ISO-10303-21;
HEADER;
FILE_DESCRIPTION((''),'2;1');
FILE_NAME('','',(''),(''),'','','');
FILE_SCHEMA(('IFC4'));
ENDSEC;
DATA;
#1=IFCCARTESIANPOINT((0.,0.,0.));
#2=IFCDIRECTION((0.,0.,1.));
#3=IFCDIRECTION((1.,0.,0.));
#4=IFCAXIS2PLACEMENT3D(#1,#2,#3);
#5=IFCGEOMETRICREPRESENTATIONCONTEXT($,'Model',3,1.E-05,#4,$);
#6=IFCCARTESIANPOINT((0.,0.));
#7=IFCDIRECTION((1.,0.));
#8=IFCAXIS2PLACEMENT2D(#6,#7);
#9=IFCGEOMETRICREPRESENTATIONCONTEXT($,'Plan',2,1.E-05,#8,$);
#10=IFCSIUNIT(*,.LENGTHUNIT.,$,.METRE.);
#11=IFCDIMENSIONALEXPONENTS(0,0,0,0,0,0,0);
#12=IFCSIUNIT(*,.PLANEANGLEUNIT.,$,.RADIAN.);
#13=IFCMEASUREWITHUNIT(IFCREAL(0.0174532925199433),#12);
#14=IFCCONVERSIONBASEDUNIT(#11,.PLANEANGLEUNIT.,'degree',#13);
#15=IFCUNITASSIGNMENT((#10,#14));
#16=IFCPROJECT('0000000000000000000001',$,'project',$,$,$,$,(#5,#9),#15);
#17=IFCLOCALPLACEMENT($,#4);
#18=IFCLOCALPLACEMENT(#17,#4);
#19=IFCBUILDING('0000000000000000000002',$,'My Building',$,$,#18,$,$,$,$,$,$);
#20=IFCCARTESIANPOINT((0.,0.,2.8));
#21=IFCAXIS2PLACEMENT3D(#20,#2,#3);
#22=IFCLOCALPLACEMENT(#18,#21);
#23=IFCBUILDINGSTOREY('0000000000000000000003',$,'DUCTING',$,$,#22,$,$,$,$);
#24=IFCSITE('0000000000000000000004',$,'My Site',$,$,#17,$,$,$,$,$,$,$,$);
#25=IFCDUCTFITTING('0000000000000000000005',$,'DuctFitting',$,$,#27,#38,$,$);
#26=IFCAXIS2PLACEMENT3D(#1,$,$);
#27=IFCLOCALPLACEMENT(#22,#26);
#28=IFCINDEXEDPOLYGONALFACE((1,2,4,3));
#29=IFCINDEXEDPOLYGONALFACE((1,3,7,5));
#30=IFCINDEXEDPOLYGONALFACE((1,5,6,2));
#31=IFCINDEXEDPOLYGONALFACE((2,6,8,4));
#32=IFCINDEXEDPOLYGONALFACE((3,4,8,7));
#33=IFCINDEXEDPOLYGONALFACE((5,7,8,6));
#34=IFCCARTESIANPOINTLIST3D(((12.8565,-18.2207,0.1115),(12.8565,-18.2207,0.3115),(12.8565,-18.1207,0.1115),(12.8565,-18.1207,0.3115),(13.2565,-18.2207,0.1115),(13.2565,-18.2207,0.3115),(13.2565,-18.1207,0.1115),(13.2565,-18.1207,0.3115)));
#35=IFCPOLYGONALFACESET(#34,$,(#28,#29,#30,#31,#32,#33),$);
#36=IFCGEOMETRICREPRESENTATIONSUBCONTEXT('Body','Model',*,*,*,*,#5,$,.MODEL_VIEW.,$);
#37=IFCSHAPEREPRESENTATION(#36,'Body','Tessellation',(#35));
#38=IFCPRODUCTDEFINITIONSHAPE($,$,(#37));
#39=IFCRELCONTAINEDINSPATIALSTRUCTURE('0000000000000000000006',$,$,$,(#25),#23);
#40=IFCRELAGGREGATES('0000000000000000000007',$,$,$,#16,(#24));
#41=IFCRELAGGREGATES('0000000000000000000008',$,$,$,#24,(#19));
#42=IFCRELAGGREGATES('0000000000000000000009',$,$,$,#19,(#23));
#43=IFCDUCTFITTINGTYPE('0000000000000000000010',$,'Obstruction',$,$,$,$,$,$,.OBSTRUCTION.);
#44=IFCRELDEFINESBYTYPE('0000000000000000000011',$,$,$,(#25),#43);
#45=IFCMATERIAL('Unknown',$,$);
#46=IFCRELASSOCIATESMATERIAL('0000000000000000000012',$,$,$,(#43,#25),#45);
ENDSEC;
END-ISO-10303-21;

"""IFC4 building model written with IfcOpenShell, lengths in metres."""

from ifc_helpers import new_model, entity, si_unit, converted_unit, frame, origin_with_axes, origin_2d_with_axis, place, context, subcontext, project, spatial, rectangle, extrude, material, material_profile, profile_set, profile_usage, type_object, element, save


model = new_model("IFC4")

# Units and contexts
model_context = context("Model", 3, precision=1e-05, world=origin_with_axes())
plan_context = context("Plan", 2, precision=1e-05, world=origin_2d_with_axis())
body_context = subcontext(model_context, "Body", "Model", "MODEL_VIEW")
ifc_project = project(units=[si_unit("LENGTHUNIT", "METRE"), converted_unit("PLANEANGLEUNIT", "degree", entity("IfcReal", 0.0174532925199433), si_unit("PLANEANGLEUNIT", "RADIAN"), dimensions=[0, 0, 0, 0, 0, 0, 0])], contexts=[model_context, plan_context])

# Site, building, storey
site_placement = place(None, origin_with_axes())
site = spatial("IfcSite", under=ifc_project, at=site_placement, Name="My Site")
building_placement = place(site_placement, origin_with_axes())
building = spatial("IfcBuilding", under=site, at=building_placement, Name="My Building")
storey_placement = place(building_placement, frame((0.0, 0.0, 2.8), z_axis=(0.0, 0.0, 1.0), x_axis=(1.0, 0.0, 0.0)))
storey = spatial("IfcBuildingStorey", under=building, at=storey_placement, Name="DUCTING")

# Shared definitions
ifc_material = material(Name="Unknown")

# Duct fitting
ifc_material_profile_1 = material_profile(ifc_material, rectangle(XDim=0.4, YDim=0.2))
ifc_profile_set_1 = profile_set([ifc_material_profile_1])
duct_fitting_type_1 = type_object("IfcDuctFittingType", Name="Obstruction", PredefinedType="OBSTRUCTION", material=ifc_profile_set_1)
ifc_profile_usage_1 = profile_usage(ifc_profile_set_1, cardinal=5)
duct_fitting_1_placement = place(storey_placement, frame((13.0565, -18.1207, 0.2115), z_axis=(-0.000018, -1.0, 0.000001), x_axis=(1.0, -0.000018, 0.0)))
element("IfcDuctFitting", 1, at=duct_fitting_1_placement, inside=storey, type_object=duct_fitting_type_1, material=ifc_profile_usage_1, Name="DuctFitting", context=body_context, shape_type="SweptSolid", body=[
    extrude(rectangle(XDim=0.4, YDim=0.2), origin_with_axes(), (0.0, 0.0, 1.0), 0.1),
])

save(model, "model.ifc")
